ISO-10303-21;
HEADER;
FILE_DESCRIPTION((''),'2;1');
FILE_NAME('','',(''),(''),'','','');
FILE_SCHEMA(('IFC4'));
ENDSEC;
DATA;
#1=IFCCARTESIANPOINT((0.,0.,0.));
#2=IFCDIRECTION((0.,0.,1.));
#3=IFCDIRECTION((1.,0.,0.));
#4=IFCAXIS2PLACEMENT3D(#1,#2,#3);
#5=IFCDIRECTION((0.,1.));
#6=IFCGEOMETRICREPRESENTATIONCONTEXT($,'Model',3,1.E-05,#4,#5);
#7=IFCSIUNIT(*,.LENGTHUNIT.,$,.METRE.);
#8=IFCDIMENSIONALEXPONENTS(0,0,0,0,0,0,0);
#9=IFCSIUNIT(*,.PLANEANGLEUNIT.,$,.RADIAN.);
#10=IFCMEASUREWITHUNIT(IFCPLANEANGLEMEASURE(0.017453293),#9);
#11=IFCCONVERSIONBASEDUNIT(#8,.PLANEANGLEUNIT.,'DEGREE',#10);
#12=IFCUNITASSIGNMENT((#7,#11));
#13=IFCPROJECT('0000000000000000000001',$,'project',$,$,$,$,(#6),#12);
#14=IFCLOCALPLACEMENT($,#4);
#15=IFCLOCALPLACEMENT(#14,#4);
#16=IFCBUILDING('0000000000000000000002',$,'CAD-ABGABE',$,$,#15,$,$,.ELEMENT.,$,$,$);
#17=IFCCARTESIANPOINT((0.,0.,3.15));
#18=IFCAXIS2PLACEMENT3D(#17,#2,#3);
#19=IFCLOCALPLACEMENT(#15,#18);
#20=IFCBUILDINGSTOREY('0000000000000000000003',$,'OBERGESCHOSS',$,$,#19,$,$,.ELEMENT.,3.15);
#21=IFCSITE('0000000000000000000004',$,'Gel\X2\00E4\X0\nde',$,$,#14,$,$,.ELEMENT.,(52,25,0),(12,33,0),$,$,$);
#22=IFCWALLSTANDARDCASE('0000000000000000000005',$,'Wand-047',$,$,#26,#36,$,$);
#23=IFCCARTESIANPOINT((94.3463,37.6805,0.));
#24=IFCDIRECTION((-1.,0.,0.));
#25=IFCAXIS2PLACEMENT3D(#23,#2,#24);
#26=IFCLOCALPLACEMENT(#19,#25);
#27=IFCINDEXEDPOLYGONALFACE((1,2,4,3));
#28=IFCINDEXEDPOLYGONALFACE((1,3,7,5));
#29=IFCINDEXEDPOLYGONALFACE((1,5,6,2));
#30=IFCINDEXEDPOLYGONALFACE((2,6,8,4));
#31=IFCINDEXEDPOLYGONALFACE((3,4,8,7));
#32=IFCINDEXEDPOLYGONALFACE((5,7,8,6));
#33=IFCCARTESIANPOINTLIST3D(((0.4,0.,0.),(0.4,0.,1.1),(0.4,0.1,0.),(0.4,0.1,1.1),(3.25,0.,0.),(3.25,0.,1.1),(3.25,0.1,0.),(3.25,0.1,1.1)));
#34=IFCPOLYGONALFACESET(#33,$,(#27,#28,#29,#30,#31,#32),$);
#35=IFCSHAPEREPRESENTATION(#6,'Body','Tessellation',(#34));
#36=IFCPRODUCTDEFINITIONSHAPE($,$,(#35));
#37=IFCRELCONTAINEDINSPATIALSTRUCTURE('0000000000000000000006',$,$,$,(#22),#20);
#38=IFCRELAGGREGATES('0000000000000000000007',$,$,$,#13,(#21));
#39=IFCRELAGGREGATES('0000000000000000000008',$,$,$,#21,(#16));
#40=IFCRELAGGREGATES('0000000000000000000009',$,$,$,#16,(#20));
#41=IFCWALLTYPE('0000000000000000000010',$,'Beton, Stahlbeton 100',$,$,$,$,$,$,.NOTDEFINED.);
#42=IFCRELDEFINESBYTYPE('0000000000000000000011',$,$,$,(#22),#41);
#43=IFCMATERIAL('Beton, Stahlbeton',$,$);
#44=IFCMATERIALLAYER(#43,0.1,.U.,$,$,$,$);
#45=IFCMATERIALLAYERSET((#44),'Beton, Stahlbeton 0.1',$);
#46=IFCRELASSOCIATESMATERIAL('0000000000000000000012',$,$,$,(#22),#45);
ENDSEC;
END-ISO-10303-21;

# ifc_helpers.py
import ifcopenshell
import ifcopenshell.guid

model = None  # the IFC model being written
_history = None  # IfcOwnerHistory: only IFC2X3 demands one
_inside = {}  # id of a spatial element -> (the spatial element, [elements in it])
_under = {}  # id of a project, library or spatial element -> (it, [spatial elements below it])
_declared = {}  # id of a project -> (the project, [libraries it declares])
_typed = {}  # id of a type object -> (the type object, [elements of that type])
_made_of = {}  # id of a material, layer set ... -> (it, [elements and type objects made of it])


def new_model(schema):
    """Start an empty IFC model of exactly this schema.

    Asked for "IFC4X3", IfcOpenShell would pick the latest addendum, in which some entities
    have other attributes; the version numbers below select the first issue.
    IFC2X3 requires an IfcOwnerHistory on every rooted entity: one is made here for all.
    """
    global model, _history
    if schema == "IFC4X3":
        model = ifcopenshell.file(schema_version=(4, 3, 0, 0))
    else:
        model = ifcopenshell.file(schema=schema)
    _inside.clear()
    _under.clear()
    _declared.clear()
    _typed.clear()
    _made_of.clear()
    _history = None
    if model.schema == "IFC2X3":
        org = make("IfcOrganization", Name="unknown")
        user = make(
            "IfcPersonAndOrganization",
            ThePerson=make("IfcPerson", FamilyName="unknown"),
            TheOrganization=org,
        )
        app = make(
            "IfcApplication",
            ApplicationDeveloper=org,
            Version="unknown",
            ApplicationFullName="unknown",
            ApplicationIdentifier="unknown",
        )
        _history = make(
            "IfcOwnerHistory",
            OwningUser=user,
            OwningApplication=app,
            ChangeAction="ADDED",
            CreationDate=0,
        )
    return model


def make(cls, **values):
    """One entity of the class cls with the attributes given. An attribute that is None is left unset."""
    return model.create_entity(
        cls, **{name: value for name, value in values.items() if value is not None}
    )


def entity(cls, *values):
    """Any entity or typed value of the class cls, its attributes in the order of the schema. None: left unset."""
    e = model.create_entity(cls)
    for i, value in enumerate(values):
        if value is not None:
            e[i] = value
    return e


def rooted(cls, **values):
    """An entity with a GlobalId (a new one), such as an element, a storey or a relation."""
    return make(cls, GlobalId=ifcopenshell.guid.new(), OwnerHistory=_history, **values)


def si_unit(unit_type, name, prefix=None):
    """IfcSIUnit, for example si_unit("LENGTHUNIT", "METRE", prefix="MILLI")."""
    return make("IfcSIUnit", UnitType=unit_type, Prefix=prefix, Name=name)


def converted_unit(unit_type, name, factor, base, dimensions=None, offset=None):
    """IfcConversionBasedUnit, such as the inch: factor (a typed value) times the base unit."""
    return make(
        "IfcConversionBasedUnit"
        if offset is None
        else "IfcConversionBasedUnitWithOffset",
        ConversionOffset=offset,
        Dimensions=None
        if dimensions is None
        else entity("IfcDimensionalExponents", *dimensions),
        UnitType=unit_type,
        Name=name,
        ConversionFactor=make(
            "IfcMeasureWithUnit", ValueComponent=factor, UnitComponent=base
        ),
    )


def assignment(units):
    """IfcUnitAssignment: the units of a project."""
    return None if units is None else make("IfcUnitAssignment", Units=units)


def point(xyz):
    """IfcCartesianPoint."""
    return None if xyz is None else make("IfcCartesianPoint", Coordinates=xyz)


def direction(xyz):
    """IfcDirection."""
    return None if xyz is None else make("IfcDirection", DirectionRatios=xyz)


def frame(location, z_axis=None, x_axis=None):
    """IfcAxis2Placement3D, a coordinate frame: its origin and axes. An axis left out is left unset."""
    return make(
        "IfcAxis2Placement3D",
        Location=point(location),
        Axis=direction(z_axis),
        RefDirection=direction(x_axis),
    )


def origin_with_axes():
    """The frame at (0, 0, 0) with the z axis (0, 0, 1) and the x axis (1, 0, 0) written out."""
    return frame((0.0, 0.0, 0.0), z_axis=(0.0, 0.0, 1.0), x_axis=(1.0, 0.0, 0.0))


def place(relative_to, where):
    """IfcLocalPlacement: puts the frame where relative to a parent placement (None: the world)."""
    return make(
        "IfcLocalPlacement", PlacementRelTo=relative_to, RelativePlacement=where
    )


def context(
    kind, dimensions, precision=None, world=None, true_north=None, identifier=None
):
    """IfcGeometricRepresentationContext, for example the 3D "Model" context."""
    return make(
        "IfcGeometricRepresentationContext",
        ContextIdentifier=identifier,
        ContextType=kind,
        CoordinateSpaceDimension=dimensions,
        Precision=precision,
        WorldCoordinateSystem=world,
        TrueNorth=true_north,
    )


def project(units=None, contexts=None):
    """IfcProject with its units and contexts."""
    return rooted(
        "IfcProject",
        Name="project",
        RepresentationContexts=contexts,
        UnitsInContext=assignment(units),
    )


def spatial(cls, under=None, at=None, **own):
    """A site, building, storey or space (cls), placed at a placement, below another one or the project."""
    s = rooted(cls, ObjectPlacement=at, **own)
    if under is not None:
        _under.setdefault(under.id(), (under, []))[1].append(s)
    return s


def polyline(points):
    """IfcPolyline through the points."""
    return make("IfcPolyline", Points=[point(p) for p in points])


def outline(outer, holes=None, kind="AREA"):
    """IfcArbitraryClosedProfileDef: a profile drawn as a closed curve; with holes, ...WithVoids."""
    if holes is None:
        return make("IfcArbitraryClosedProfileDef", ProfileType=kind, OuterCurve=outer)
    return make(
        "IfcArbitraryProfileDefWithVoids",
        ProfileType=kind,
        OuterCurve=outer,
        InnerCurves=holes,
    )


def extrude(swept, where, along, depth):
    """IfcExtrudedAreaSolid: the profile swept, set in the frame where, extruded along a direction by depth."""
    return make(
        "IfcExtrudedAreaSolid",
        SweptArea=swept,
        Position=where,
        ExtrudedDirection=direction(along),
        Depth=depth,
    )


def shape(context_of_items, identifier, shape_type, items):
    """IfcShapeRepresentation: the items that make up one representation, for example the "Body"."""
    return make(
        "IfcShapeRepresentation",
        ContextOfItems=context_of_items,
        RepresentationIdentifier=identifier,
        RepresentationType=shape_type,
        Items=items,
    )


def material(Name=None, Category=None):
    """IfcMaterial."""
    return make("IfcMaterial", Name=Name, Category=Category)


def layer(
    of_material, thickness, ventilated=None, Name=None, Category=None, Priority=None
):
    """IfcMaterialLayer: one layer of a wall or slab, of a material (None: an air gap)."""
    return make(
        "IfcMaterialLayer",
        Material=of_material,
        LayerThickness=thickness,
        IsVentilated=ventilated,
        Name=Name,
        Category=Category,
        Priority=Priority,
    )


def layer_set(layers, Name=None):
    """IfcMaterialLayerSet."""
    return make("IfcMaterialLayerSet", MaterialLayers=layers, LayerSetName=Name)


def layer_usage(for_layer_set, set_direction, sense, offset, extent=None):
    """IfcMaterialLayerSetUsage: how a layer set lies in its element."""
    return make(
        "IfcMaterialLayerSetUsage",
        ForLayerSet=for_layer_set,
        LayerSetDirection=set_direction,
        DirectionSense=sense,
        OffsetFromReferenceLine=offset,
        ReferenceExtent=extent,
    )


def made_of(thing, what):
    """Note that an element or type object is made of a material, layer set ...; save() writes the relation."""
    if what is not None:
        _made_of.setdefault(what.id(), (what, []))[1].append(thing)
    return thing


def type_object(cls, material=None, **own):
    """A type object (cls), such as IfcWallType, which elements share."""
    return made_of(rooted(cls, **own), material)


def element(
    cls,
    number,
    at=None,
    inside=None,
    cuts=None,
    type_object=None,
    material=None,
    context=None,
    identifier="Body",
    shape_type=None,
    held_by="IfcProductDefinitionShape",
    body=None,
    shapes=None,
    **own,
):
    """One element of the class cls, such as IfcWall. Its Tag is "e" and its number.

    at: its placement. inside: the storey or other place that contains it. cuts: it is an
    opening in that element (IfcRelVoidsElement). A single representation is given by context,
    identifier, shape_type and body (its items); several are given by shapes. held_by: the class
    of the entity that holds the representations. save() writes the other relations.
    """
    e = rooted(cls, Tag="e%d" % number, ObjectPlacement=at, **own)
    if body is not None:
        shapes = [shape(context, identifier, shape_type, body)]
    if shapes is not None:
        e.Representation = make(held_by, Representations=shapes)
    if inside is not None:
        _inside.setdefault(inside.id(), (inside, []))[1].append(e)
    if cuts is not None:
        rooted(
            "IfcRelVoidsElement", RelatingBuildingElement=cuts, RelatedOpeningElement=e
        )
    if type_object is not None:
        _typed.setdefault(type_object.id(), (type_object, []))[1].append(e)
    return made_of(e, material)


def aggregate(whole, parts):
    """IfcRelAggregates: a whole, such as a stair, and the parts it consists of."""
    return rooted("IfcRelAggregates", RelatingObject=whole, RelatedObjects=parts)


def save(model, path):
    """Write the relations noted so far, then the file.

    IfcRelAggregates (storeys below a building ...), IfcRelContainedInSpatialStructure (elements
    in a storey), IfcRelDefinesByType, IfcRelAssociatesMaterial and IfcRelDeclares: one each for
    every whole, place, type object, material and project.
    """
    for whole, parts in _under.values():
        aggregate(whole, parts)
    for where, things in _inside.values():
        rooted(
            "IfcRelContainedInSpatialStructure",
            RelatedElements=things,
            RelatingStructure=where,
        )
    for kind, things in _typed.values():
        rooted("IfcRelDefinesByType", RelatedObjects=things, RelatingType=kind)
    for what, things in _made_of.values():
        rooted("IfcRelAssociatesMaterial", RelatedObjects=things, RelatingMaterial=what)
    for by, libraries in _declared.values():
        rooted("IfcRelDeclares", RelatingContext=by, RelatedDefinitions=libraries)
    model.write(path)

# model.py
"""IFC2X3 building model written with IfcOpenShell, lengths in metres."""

from ifc_helpers import new_model, entity, si_unit, converted_unit, direction, frame, origin_with_axes, place, context, project, spatial, polyline, outline, extrude, material, layer, layer_set, layer_usage, type_object, element, save


model = new_model("IFC2X3")

# Units and contexts
model_context = context("Model", 3, precision=1e-05, world=origin_with_axes(), true_north=direction((0.0, 1.0)))
ifc_project = project(units=[si_unit("LENGTHUNIT", "METRE"), converted_unit("PLANEANGLEUNIT", "DEGREE", entity("IfcPlaneAngleMeasure", 0.017453293), si_unit("PLANEANGLEUNIT", "RADIAN"), dimensions=[0, 0, 0, 0, 0, 0, 0])], contexts=[model_context])

# Site, building, storey
site_placement = place(None, origin_with_axes())
site = spatial("IfcSite", under=ifc_project, at=site_placement, Name="Gelände", CompositionType="ELEMENT", RefLatitude=(52, 25, 0), RefLongitude=(12, 33, 0))
building_placement = place(site_placement, origin_with_axes())
building = spatial("IfcBuilding", under=site, at=building_placement, Name="CAD-ABGABE", CompositionType="ELEMENT")
storey_placement = place(building_placement, frame((0.0, 0.0, 3.15), z_axis=(0.0, 0.0, 1.0), x_axis=(1.0, 0.0, 0.0)))
storey = spatial("IfcBuildingStorey", under=building, at=storey_placement, Name="OBERGESCHOSS", CompositionType="ELEMENT", Elevation=3.15)

# Shared definitions
ifc_material = material(Name="Beton, Stahlbeton")

# Shared definitions
ifc_layer_1 = layer(ifc_material, 0.1, ventilated="UNKNOWN")
ifc_layer_set_1 = layer_set([ifc_layer_1], Name="Beton, Stahlbeton 0.1")
wall_type_1 = type_object("IfcWallType", Name="Beton, Stahlbeton 100", PredefinedType="NOTDEFINED")

# Wall
ifc_layer_usage_1 = layer_usage(ifc_layer_set_1, "AXIS2", "POSITIVE", 0.0)
wall_1_placement = place(storey_placement, frame((94.3463, 37.6805, 0.0), z_axis=(0.0, 0.0, 1.0), x_axis=(-1.0, 0.0, 0.0)))
element("IfcWallStandardCase", 1, at=wall_1_placement, inside=storey, type_object=wall_type_1, material=ifc_layer_usage_1, Name="Wand-047", context=model_context, shape_type="SweptSolid", body=[
    extrude(outline(polyline([(0.4, 0.0), (3.25, 0.0), (3.25, 0.1), (0.4, 0.1), (0.4, 0.0)])), origin_with_axes(), (0.0, 0.0, 1.0), 1.1),
])

save(model, "model.ifc")
